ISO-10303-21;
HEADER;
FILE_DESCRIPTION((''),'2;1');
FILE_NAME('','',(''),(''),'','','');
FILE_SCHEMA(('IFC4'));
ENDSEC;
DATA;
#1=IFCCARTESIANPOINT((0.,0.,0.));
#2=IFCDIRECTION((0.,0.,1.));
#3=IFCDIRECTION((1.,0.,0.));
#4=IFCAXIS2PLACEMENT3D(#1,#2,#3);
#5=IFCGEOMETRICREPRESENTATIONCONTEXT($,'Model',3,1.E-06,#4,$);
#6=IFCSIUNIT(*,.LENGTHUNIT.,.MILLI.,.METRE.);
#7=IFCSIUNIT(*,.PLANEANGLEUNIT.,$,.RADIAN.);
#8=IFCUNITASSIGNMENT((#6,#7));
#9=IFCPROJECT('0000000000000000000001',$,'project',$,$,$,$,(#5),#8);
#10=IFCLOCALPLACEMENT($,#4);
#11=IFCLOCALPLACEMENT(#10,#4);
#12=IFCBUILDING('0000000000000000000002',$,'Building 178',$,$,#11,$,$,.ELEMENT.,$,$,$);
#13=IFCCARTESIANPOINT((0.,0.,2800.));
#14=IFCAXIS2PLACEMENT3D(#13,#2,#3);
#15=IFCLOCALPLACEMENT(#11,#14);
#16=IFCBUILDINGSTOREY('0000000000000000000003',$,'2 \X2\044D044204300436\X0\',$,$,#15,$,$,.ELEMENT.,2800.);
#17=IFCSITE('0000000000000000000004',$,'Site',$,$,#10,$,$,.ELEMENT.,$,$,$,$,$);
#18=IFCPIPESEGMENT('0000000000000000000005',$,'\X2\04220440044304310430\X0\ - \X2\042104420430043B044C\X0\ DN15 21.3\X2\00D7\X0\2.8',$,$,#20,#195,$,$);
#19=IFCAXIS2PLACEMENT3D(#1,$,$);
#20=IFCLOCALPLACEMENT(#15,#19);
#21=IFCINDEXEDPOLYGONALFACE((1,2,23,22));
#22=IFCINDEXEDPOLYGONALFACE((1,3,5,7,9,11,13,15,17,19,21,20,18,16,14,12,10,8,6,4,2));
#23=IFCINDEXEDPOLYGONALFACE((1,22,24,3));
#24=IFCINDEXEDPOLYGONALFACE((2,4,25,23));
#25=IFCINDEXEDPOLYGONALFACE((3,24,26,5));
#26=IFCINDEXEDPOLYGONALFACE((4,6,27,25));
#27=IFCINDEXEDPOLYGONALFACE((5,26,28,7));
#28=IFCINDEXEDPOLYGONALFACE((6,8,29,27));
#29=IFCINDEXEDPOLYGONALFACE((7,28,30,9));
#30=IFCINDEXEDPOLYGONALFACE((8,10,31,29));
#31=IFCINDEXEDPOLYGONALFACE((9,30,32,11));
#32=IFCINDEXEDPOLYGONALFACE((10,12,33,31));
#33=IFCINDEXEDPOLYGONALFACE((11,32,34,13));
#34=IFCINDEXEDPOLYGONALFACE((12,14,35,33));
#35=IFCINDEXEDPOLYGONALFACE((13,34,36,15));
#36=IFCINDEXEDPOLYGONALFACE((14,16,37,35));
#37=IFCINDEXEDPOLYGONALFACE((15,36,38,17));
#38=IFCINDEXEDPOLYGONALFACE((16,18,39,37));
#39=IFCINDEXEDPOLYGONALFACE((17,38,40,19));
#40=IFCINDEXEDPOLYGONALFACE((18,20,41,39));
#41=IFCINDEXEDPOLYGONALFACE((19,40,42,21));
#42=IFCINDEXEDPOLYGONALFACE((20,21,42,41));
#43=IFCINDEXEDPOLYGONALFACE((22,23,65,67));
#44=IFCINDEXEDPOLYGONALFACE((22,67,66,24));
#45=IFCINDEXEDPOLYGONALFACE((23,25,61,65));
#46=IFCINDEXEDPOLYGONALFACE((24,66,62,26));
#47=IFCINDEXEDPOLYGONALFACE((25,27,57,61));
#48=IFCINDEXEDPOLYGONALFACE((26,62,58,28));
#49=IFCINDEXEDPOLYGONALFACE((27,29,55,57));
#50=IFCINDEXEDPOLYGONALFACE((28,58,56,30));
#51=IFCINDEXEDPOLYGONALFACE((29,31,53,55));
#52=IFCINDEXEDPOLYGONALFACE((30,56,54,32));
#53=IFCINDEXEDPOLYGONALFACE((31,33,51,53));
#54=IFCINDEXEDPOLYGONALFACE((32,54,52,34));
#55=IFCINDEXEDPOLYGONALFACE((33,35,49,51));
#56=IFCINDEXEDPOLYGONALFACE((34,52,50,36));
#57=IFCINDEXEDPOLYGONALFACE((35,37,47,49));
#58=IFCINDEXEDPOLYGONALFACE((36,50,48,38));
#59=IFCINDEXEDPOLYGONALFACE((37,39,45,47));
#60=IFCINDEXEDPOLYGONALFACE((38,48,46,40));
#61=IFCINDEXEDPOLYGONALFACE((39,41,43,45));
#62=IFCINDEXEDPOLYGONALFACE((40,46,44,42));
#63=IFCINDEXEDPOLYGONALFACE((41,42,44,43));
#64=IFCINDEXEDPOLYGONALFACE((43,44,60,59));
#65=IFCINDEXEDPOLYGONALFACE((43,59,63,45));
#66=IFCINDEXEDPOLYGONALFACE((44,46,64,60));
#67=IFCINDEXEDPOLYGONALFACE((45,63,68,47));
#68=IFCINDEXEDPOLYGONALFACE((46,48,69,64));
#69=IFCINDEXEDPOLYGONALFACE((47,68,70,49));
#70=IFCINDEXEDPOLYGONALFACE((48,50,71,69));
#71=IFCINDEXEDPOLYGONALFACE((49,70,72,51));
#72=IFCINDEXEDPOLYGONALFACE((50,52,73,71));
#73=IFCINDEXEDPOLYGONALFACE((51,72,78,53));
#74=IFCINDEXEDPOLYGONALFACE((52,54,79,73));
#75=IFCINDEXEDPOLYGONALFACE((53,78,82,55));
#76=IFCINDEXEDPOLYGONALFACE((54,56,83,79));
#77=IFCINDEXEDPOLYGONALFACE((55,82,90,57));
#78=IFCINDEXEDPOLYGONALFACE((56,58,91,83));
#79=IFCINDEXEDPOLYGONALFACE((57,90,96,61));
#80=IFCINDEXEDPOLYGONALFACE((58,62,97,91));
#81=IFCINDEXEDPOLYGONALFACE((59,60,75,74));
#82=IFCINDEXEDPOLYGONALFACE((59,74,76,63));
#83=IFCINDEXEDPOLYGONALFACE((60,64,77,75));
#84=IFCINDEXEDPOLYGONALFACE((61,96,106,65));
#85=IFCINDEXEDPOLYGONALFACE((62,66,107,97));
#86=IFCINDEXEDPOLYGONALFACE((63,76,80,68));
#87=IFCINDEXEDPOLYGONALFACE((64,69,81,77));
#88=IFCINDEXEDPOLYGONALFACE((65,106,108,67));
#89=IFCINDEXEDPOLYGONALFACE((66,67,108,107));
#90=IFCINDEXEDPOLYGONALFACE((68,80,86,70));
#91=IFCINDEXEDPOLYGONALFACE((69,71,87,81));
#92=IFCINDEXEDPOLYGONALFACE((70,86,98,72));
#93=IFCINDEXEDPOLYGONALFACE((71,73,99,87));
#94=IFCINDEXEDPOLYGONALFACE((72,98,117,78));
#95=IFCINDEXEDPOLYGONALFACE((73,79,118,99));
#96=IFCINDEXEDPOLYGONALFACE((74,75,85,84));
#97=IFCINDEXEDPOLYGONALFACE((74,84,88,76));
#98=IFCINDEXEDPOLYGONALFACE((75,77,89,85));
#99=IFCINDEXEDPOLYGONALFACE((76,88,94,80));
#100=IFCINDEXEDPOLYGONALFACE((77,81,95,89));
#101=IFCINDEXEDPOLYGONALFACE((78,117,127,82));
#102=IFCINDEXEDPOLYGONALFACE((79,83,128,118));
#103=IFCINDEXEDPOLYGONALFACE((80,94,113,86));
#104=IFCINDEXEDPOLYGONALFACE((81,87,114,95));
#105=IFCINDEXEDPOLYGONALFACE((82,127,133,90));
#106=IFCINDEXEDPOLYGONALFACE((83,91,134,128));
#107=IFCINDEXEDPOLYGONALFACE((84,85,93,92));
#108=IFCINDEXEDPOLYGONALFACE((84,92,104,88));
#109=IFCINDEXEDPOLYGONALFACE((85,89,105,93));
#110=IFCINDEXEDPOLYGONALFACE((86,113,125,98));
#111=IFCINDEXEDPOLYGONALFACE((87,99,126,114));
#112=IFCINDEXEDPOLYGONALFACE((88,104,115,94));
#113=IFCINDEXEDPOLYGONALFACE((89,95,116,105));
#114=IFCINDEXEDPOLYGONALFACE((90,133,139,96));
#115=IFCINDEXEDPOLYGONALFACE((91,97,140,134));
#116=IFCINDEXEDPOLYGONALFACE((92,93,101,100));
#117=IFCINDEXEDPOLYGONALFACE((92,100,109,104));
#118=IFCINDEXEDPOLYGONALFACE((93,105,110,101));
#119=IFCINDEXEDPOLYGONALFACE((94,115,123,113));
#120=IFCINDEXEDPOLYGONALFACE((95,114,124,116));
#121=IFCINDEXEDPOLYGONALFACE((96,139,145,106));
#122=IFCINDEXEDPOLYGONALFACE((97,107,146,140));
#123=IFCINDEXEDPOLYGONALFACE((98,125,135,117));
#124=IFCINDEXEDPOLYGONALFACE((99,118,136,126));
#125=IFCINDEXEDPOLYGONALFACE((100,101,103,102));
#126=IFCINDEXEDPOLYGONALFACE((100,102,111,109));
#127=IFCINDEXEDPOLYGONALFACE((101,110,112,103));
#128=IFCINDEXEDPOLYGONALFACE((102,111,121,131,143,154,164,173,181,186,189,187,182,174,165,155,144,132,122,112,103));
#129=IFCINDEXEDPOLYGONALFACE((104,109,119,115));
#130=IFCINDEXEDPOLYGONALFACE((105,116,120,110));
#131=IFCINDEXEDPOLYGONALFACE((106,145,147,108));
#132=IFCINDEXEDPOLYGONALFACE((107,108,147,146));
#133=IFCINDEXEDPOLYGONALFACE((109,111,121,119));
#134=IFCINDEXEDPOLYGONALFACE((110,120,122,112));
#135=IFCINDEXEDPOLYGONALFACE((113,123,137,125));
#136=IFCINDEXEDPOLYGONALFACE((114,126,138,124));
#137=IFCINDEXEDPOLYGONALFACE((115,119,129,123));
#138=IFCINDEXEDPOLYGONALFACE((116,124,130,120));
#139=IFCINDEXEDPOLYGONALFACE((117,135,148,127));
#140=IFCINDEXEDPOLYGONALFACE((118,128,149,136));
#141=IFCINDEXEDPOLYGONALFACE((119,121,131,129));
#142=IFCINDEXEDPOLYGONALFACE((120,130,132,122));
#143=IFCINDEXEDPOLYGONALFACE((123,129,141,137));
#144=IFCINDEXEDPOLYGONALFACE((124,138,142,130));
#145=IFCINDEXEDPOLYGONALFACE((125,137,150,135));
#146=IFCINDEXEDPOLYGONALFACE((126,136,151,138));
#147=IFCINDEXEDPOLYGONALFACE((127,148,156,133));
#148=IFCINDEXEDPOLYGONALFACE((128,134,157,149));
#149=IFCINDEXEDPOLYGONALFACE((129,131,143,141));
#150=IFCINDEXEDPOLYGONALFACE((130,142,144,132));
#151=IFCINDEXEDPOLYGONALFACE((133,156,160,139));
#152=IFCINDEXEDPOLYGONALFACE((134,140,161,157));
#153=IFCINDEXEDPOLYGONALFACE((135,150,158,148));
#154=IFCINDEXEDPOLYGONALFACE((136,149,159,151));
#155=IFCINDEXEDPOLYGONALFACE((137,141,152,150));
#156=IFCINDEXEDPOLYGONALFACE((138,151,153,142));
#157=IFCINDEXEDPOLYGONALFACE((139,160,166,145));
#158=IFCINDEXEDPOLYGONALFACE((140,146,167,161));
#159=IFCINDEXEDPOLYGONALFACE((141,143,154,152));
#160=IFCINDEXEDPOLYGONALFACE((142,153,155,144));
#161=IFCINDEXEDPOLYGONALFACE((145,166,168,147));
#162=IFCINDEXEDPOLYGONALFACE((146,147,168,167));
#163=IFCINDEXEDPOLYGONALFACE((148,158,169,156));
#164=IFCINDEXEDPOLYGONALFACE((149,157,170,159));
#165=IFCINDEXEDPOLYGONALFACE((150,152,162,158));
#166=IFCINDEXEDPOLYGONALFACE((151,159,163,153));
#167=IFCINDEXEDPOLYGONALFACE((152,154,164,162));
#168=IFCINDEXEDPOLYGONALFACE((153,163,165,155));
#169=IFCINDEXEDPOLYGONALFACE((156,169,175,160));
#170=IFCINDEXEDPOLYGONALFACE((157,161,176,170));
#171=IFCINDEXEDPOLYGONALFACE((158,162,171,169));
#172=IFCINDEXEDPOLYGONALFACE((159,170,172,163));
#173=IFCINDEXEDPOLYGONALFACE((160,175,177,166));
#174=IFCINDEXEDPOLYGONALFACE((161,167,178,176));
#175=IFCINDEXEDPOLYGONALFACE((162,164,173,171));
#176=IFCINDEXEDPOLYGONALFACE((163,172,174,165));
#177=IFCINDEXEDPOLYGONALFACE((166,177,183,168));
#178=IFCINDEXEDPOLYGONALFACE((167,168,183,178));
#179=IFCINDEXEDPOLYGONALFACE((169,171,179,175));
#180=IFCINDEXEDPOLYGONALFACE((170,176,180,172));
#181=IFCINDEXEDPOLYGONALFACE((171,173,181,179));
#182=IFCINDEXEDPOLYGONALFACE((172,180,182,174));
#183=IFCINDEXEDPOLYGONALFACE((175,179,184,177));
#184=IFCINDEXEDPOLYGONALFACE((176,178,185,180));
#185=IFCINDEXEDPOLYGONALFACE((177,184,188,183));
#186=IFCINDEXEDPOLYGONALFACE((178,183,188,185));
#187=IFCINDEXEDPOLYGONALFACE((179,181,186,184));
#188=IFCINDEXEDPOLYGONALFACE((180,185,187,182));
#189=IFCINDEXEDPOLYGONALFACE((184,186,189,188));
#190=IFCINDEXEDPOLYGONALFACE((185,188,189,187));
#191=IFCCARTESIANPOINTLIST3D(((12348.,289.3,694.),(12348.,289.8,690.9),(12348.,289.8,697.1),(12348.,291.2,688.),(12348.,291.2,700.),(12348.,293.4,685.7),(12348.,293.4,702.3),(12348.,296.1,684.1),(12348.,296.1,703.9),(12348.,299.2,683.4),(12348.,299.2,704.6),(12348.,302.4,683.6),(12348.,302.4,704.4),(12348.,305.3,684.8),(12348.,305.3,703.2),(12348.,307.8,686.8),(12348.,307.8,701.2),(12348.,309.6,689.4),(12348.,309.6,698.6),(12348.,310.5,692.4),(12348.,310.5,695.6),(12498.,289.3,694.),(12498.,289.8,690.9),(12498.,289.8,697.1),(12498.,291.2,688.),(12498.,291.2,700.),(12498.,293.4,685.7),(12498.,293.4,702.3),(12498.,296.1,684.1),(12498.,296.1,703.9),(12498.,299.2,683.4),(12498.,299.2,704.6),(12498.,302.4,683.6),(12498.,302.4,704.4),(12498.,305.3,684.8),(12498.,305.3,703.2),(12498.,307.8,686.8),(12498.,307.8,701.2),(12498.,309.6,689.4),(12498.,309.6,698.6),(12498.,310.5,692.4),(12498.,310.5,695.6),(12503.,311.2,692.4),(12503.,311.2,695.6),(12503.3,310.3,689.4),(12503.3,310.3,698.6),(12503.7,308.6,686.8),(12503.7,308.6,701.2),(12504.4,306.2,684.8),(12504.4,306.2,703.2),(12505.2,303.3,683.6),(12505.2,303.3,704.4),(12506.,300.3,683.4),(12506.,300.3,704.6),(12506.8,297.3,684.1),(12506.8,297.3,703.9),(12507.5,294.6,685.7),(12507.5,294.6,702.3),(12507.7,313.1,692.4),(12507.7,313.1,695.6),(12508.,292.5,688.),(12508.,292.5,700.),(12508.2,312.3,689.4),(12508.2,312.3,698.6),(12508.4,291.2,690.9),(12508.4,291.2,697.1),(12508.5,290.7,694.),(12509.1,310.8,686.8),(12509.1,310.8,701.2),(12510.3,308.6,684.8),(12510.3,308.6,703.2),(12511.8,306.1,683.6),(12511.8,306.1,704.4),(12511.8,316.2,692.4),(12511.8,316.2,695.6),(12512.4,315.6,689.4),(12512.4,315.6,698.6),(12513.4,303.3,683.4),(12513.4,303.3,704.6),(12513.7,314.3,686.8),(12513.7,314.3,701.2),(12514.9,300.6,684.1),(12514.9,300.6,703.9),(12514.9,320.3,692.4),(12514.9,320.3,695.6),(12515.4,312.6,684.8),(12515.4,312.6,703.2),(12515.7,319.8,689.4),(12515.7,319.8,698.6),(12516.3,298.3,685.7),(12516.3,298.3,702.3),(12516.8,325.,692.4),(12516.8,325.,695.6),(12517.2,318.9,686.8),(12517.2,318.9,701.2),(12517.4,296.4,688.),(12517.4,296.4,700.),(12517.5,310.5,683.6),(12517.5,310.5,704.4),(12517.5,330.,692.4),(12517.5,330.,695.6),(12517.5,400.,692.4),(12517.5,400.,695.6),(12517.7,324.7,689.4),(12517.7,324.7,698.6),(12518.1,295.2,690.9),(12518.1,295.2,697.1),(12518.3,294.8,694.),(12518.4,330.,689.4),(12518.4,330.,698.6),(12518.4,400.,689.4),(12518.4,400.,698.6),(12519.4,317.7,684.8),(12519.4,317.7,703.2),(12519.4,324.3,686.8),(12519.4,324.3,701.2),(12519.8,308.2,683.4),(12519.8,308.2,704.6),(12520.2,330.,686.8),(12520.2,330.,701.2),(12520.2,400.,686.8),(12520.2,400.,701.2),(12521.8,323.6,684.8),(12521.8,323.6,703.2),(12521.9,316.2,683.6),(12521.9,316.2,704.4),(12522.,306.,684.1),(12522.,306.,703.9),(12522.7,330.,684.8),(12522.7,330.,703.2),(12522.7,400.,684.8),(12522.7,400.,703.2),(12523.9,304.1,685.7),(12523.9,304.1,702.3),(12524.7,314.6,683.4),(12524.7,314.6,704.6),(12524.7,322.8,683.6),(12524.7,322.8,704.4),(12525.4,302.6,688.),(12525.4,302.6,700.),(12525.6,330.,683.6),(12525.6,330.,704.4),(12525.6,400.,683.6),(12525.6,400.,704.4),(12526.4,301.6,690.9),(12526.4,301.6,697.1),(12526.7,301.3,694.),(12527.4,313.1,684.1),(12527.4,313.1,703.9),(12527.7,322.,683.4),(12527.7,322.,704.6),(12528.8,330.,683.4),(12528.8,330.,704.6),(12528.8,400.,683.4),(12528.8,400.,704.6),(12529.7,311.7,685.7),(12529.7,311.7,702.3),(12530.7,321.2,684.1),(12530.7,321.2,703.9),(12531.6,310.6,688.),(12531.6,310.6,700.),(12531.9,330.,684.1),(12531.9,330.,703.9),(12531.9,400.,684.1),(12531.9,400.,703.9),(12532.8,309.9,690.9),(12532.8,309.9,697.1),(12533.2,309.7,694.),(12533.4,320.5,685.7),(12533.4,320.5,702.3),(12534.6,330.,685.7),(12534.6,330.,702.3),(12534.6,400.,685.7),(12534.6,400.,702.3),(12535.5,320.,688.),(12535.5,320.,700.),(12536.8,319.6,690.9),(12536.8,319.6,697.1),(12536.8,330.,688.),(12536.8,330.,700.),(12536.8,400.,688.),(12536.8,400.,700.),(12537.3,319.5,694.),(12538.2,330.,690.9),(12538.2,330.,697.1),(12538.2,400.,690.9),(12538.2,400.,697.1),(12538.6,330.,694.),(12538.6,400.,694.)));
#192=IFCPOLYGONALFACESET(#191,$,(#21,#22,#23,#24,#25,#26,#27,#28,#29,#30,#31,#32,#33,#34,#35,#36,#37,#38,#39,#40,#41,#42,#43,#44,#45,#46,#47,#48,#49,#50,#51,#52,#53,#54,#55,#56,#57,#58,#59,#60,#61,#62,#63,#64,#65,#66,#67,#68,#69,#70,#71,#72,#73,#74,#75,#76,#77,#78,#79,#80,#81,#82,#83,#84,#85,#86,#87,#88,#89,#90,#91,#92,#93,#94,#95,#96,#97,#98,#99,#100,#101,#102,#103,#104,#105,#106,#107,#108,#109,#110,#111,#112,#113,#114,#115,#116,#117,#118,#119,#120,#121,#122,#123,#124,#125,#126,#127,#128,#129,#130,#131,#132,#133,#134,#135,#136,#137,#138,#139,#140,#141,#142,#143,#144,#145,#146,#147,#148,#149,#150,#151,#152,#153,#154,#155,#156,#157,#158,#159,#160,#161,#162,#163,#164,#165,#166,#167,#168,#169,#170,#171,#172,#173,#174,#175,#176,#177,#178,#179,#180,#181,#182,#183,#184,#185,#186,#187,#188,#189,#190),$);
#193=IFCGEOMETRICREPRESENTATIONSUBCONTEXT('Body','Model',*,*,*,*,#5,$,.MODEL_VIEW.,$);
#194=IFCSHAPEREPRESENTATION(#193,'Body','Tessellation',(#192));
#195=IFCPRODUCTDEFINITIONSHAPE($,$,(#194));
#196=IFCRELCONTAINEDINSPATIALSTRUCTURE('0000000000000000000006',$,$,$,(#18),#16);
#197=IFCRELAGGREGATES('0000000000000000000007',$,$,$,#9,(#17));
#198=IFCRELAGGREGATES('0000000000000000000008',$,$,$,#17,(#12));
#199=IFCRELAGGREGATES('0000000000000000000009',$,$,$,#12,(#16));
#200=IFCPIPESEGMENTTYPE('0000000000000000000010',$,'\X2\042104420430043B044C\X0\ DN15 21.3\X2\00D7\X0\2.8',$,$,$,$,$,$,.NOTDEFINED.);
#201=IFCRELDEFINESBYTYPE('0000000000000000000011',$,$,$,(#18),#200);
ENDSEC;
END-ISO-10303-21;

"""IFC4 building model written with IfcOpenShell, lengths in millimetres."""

from ifc_helpers import new_model, entity, si_unit, frame, origin_with_axes, place, context, subcontext, project, spatial, source, transform, mapped, type_object, element, save


model = new_model("IFC4")

# Units and contexts
model_context = context("Model", 3, precision=1e-06, world=origin_with_axes())
body_context = subcontext(model_context, "Body", "Model", "MODEL_VIEW")
ifc_project = project(units=[si_unit("LENGTHUNIT", "METRE", prefix="MILLI"), si_unit("PLANEANGLEUNIT", "RADIAN")], contexts=[model_context])

# Site, building, storey
site_placement = place(None, origin_with_axes())
site = spatial("IfcSite", under=ifc_project, at=site_placement, Name="Site", CompositionType="ELEMENT")
building_placement = place(site_placement, origin_with_axes())
building = spatial("IfcBuilding", under=site, at=building_placement, Name="Building 178", CompositionType="ELEMENT")
storey_placement = place(building_placement, frame((0.0, 0.0, 2800.0), z_axis=(0.0, 0.0, 1.0), x_axis=(1.0, 0.0, 0.0)))
storey = spatial("IfcBuildingStorey", under=building, at=storey_placement, Name="2 этаж", CompositionType="ELEMENT", Elevation=2800.0)

# Pipe segment
pipe_segment_type = type_object("IfcPipeSegmentType", Name="Сталь DN15 21.3×2.8", PredefinedType="NOTDEFINED")
shared_shape_1 = source(origin_with_axes(), body_context, "Body", "AdvancedSweptSolid", [
    entity("IfcSweptDiskSolid", entity("IfcIndexedPolyCurve", entity("IfcCartesianPointList3D", [[0.0, 0.0, 0.0], [0.0, 0.0, -70.0], [8.8, 0.0, -91.2], [30.0, 0.0, -100.0], [180.0, 0.0, -100.0]]), [entity("IfcLineIndex", [1, 2]), entity("IfcArcIndex", [2, 3, 4]), entity("IfcLineIndex", [4, 5])]), 10.7),
])
for number, where, z_axis, x_axis, name in (
    (1, (12528.0, 400.0, 694.0), (0.0, 1.0, 0.0), (-1.0, 0.0, 0.0), "Труба - Сталь DN15 21.3×2.8"),
):
    element("IfcPipeSegment", number, at=place(storey_placement, frame(where, z_axis=z_axis, x_axis=x_axis)), inside=storey, type_object=pipe_segment_type, Name=name, context=body_context, shape_type="MappedRepresentation", body=[
        mapped(shared_shape_1, transform((0.0, 0.0, 0.0), x_axis=(1.0, 0.0, 0.0), y_axis=(0.0, 1.0, 0.0), z_axis=(0.0, 0.0, 1.0), scale=1.0)),
    ])

save(model, "model.ifc")
